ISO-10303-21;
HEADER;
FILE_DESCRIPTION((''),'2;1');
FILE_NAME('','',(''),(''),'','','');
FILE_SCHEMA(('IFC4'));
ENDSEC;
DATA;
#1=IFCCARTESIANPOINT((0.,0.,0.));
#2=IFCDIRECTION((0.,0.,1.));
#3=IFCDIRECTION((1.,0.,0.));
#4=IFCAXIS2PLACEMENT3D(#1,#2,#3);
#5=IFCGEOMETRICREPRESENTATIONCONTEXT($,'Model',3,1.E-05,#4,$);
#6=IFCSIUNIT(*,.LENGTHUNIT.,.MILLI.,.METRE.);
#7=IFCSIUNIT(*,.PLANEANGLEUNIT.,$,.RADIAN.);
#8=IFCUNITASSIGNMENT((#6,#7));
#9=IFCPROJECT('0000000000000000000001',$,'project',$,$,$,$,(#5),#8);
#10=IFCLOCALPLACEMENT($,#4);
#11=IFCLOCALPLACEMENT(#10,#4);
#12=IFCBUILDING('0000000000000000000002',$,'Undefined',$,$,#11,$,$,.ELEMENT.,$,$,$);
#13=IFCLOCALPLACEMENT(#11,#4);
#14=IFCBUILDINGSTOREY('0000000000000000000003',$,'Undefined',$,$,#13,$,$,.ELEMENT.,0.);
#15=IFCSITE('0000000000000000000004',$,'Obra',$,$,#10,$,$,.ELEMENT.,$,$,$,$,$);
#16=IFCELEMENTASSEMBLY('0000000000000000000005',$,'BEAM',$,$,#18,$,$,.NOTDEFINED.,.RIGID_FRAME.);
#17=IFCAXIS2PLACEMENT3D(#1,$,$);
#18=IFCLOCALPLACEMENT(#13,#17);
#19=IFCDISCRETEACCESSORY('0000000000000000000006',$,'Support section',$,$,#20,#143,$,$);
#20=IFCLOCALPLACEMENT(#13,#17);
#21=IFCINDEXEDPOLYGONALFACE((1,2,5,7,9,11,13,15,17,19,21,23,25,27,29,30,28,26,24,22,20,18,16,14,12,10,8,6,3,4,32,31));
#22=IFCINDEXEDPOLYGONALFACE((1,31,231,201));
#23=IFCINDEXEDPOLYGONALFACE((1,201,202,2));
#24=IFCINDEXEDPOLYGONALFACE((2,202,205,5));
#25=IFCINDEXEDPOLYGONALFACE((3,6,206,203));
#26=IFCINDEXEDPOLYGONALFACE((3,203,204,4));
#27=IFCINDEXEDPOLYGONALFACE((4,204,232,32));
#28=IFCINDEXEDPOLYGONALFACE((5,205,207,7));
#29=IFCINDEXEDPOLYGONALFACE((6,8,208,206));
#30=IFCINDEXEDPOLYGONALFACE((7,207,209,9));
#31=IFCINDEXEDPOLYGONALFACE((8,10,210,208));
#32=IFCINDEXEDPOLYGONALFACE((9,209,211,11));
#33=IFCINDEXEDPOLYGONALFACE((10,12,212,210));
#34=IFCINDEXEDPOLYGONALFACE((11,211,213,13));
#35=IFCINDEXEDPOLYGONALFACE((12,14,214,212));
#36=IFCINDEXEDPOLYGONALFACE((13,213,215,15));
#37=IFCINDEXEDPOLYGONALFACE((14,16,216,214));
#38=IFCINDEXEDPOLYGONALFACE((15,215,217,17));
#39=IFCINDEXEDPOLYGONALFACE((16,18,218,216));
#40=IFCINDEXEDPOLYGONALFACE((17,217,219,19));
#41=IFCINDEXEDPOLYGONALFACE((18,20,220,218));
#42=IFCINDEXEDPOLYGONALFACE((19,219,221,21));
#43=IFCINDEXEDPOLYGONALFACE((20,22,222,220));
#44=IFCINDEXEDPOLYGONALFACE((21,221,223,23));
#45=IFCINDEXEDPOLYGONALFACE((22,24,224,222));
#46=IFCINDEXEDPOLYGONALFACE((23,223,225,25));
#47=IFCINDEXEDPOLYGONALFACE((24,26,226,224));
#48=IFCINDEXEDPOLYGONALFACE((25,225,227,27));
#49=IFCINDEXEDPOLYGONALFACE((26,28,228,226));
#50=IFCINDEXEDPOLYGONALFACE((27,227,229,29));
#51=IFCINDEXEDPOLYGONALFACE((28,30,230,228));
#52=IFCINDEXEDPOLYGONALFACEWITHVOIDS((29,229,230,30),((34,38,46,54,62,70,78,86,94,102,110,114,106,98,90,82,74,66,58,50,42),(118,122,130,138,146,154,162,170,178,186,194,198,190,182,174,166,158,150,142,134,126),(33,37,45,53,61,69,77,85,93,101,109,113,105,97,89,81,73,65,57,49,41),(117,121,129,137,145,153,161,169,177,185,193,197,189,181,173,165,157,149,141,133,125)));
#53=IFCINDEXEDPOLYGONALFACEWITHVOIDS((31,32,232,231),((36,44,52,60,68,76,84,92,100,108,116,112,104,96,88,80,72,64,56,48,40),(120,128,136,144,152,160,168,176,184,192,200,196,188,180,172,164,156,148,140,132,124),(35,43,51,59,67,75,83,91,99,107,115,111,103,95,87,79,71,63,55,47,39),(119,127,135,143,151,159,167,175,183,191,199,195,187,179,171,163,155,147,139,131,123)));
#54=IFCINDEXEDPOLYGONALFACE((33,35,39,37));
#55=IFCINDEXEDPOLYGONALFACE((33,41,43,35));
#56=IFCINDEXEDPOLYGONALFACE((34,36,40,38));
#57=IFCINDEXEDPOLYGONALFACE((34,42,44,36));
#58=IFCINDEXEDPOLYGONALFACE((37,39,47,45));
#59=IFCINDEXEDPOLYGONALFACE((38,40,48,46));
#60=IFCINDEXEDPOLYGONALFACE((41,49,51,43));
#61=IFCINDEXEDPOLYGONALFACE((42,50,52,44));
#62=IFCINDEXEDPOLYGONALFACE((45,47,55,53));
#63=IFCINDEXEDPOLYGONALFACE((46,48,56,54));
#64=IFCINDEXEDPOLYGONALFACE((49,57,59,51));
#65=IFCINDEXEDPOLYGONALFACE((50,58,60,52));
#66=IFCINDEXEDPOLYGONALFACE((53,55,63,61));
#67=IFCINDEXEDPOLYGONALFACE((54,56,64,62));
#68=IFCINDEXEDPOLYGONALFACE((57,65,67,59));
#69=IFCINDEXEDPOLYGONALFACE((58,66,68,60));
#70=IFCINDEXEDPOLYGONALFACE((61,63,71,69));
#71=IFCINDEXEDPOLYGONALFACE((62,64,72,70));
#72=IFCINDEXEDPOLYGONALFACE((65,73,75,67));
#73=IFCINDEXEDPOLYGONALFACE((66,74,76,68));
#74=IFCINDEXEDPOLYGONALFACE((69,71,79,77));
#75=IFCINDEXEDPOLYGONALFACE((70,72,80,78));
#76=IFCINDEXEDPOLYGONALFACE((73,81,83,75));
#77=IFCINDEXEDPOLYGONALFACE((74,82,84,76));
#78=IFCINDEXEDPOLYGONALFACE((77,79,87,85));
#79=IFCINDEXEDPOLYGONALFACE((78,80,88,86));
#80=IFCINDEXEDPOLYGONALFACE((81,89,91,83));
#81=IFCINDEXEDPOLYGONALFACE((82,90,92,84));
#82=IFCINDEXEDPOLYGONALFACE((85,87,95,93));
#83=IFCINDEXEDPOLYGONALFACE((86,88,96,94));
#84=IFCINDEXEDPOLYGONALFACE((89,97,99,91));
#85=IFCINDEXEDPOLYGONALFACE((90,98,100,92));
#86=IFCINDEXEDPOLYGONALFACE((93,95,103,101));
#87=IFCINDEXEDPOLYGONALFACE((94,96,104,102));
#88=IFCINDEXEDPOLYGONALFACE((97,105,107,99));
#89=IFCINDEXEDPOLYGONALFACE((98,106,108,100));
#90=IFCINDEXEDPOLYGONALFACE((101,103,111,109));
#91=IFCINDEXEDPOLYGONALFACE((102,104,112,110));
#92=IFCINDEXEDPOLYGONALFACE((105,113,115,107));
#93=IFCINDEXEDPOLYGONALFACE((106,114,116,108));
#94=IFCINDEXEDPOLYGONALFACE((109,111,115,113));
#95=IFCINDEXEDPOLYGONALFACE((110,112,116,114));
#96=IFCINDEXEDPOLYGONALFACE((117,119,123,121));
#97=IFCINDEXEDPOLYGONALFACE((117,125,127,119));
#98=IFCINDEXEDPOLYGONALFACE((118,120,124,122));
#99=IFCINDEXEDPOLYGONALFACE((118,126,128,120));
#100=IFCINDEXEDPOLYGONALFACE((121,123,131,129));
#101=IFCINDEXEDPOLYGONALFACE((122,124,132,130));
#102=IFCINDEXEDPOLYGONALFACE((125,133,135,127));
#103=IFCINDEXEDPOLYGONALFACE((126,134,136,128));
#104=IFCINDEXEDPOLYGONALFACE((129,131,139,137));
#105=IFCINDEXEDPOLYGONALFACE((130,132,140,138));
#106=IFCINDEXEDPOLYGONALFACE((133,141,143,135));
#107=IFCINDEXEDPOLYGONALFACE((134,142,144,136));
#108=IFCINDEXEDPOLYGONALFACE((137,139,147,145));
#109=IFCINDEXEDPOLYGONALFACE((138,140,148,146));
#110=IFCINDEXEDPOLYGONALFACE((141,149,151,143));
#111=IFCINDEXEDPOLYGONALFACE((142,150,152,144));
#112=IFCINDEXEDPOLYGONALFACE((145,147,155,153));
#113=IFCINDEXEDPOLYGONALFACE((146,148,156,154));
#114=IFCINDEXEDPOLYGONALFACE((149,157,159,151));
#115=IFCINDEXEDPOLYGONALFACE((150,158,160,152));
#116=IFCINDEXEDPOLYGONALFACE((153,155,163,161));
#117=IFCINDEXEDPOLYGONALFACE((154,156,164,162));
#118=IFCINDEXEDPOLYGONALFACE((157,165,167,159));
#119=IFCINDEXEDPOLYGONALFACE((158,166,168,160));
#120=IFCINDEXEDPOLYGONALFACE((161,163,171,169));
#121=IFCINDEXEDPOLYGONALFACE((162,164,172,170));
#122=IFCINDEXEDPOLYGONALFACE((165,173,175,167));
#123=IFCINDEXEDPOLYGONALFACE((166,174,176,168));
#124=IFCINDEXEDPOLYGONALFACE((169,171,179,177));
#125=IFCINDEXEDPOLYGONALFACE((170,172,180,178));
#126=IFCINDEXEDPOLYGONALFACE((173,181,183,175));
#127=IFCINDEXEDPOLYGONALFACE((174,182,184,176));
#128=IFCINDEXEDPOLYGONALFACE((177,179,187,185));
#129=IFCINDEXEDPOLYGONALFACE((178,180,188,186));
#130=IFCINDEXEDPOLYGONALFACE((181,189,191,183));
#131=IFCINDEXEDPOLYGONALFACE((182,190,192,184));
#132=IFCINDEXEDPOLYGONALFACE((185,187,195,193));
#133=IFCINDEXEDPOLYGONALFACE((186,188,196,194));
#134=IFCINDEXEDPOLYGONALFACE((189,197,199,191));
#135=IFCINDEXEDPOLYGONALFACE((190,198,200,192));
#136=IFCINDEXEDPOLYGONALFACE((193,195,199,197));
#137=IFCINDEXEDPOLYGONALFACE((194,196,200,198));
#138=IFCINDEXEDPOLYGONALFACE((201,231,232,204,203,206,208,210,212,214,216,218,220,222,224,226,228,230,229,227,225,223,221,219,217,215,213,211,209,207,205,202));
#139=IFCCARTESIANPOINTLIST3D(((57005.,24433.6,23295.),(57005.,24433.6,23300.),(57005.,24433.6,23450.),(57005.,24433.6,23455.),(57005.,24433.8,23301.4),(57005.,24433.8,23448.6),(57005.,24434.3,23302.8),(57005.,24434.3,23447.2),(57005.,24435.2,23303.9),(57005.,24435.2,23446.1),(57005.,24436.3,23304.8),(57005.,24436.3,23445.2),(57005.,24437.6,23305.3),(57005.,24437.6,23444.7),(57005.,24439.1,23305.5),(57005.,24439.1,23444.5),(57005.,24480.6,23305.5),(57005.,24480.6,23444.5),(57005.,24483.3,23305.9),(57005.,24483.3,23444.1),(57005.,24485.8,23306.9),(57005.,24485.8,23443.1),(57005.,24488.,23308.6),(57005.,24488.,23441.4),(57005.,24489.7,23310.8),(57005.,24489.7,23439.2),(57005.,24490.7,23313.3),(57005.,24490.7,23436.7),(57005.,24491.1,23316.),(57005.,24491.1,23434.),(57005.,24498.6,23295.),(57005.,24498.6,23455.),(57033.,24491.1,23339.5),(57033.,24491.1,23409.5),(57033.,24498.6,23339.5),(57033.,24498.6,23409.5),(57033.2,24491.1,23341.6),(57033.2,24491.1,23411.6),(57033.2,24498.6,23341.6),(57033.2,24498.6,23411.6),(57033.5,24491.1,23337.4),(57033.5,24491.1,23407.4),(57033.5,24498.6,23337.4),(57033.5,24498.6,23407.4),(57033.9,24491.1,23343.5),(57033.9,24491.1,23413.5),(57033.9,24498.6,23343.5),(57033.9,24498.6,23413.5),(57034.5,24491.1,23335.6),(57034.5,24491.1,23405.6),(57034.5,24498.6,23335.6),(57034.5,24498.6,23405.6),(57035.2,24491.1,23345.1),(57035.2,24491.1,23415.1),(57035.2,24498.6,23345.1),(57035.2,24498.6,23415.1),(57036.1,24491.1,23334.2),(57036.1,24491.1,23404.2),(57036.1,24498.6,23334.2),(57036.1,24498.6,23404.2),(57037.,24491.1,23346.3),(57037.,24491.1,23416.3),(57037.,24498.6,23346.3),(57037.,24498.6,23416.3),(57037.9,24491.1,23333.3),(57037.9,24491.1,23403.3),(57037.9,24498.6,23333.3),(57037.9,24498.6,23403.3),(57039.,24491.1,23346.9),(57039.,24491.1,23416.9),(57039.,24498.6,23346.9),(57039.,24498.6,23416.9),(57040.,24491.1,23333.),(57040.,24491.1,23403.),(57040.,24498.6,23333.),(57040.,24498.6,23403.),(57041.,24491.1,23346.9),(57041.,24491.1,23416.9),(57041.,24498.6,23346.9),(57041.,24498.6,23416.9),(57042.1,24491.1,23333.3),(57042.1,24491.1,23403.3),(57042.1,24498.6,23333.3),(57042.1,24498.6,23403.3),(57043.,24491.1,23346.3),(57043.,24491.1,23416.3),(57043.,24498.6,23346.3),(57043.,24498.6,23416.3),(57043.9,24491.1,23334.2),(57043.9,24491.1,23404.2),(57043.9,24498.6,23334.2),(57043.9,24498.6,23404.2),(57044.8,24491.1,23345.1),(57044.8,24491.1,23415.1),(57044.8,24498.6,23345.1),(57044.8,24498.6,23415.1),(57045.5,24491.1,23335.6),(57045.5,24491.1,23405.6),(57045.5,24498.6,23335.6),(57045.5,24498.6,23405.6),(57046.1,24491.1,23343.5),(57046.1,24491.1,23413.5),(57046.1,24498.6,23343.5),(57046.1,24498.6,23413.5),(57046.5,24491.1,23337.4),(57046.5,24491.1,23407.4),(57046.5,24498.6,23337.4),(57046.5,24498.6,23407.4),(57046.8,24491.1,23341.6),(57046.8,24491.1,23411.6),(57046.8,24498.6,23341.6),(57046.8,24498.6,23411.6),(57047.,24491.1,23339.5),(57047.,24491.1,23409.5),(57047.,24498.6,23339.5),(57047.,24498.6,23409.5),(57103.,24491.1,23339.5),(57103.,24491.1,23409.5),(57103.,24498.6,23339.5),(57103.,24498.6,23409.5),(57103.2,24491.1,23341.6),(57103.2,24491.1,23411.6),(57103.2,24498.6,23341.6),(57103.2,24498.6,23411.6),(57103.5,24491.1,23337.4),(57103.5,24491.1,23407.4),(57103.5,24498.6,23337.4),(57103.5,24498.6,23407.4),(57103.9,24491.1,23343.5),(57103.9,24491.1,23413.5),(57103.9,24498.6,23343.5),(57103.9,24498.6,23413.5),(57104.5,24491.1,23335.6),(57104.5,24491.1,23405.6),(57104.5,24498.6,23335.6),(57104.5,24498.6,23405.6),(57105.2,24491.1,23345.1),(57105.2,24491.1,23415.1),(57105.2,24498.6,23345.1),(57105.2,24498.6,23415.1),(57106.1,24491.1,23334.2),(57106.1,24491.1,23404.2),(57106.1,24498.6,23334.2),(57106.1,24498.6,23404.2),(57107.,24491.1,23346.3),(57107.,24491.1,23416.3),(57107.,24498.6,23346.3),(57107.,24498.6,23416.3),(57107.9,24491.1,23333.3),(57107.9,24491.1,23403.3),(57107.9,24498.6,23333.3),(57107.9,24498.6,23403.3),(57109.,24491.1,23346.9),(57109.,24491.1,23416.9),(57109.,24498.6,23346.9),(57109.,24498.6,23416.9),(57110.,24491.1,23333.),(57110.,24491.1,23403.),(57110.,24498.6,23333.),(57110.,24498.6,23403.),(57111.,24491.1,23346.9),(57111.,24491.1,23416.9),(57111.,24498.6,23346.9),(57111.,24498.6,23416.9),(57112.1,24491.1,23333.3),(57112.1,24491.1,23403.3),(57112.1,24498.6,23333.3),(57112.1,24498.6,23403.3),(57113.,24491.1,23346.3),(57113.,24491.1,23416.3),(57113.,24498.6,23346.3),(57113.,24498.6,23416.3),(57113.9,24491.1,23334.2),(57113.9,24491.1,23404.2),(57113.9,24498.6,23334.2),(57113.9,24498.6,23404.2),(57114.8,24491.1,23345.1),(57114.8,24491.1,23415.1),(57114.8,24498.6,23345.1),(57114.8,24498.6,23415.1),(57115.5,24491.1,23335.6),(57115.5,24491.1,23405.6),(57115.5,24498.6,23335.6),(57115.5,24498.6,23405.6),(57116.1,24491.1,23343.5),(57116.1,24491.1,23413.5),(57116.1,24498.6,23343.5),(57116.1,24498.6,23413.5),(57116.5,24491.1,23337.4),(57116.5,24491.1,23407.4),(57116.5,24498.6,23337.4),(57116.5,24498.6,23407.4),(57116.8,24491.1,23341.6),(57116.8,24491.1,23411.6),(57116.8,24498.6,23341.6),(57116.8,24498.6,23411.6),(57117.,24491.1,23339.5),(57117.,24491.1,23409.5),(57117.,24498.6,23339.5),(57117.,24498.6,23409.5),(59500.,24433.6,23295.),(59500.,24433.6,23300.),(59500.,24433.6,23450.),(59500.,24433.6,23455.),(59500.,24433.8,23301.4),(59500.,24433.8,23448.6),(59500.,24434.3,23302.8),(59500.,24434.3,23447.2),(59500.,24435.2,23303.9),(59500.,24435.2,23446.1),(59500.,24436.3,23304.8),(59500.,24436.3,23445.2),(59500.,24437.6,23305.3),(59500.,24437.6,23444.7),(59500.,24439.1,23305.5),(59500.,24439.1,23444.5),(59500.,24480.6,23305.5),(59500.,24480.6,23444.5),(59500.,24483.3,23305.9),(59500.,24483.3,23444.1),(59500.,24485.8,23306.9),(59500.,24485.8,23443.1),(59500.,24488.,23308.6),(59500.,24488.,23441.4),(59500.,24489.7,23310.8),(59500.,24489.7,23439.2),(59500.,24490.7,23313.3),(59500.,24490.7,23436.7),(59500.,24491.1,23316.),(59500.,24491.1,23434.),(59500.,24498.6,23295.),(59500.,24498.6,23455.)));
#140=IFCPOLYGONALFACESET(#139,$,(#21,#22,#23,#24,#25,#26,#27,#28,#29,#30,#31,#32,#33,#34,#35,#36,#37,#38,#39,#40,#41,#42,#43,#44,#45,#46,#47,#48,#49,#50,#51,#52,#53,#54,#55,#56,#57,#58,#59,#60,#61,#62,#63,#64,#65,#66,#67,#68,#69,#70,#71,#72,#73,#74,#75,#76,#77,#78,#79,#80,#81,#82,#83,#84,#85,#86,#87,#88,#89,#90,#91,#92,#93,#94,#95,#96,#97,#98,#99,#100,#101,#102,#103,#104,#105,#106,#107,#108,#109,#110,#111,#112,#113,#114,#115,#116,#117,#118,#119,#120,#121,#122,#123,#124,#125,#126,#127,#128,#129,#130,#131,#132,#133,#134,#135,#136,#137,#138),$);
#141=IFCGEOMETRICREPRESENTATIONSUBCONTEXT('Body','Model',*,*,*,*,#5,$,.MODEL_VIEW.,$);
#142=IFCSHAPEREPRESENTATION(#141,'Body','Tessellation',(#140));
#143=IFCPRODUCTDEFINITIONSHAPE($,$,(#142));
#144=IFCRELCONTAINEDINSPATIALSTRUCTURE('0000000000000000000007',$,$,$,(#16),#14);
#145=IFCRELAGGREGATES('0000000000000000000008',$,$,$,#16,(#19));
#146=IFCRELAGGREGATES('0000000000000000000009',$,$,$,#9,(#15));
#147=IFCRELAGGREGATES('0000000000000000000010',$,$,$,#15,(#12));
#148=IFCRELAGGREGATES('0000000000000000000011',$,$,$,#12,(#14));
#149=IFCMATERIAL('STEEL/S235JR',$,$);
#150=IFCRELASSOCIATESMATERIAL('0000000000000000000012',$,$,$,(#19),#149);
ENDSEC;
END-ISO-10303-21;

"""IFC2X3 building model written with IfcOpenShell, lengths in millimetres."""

from ifc_helpers import new_model, si_unit, frame, origin_with_axes, origin_2d_with_axis, place, context, subcontext, project, spatial, circle, u_section, extrude, clip, halfspace, source, transform, mapped, material, element, aggregate, save


model = new_model("IFC2X3")

# Units and contexts
model_context = context("Model", 3, precision=1e-05, world=origin_with_axes())
body_context = subcontext(model_context, "Body", "Model", "MODEL_VIEW")
ifc_project = project(units=[si_unit("LENGTHUNIT", "METRE", prefix="MILLI"), si_unit("PLANEANGLEUNIT", "RADIAN")], contexts=[model_context])

# Site, building, storey
site_placement = place(None, origin_with_axes())
site = spatial("IfcSite", under=ifc_project, at=site_placement, Name="Obra", CompositionType="ELEMENT")
building_placement = place(site_placement, origin_with_axes())
building = spatial("IfcBuilding", under=site, at=building_placement, Name="Undefined", CompositionType="ELEMENT")
storey_placement = place(building_placement, origin_with_axes())
storey = spatial("IfcBuildingStorey", under=building, at=storey_placement, Name="Undefined", CompositionType="ELEMENT", Elevation=0.0)

# Shared definitions
ifc_material_1 = material(Name="STEEL/S235JR")

# Element assembly
assembly_1_placement = place(storey_placement, origin_with_axes())
assembly_1 = element("IfcElementAssembly", 1, at=assembly_1_placement, inside=storey, Name="BEAM", AssemblyPlace="NOTDEFINED", PredefinedType="RIGID_FRAME")

# Discrete accessory, opening
discrete_accessory_1_placement = place(assembly_1_placement, frame((57000.0, 24466.1, 23375.0), z_axis=(0.0, 0.0, 1.0), x_axis=(1.0, 0.0, 0.0)))
discrete_accessory_1 = element("IfcDiscreteAccessory", 2, at=discrete_accessory_1_placement, material=ifc_material_1, Name="Support section", context=body_context, shape_type="Clipping", body=[
    clip(extrude(u_section(Depth=160.0, FlangeWidth=65.0, WebThickness=7.5, FlangeThickness=10.5, FilletRadius=10.5, EdgeRadius=5.5, at=origin_2d_with_axis()), frame((2500.0, 0.0, 0.0), z_axis=(-1.0, 0.0, 0.0), x_axis=(0.0, -1.0, 0.0)), (0.0, 0.0, 1.0), 2495.0), halfspace(frame((5.0, 0.0, 166.3), z_axis=(-1.0, 0.0, 0.0), x_axis=(0.0, -1.0, 0.0)), False)),
])
shared_shape_1 = source(origin_with_axes(), body_context, "Body", "SweptSolid", [
    extrude(circle(Radius=7.0, at=origin_2d_with_axis()), frame((0.0, -3.9, 0.0), z_axis=(0.0, 1.0, 0.0), x_axis=(1.0, 0.0, 0.0)), (0.0, 0.0, 1.0), 7.7),
])
opening_1_placement = place(assembly_1_placement, frame((57040.0, 24494.8, 23410.0), z_axis=(1.0, 0.0, 0.0), x_axis=(0.0, 0.0, -1.0)))
element("IfcOpeningElement", 3, at=opening_1_placement, cuts=discrete_accessory_1, ObjectType="Opening", context=body_context, shape_type="MappedRepresentation", body=[
    mapped(shared_shape_1, transform((0.0, 0.0, 0.0))),
    mapped(shared_shape_1, transform((0.0, 0.0, 70.0))),
    mapped(shared_shape_1, transform((70.0, 0.0, 0.0))),
    mapped(shared_shape_1, transform((70.0, 0.0, 70.0))),
])
aggregate(assembly_1, [discrete_accessory_1])

save(model, "model.ifc")
